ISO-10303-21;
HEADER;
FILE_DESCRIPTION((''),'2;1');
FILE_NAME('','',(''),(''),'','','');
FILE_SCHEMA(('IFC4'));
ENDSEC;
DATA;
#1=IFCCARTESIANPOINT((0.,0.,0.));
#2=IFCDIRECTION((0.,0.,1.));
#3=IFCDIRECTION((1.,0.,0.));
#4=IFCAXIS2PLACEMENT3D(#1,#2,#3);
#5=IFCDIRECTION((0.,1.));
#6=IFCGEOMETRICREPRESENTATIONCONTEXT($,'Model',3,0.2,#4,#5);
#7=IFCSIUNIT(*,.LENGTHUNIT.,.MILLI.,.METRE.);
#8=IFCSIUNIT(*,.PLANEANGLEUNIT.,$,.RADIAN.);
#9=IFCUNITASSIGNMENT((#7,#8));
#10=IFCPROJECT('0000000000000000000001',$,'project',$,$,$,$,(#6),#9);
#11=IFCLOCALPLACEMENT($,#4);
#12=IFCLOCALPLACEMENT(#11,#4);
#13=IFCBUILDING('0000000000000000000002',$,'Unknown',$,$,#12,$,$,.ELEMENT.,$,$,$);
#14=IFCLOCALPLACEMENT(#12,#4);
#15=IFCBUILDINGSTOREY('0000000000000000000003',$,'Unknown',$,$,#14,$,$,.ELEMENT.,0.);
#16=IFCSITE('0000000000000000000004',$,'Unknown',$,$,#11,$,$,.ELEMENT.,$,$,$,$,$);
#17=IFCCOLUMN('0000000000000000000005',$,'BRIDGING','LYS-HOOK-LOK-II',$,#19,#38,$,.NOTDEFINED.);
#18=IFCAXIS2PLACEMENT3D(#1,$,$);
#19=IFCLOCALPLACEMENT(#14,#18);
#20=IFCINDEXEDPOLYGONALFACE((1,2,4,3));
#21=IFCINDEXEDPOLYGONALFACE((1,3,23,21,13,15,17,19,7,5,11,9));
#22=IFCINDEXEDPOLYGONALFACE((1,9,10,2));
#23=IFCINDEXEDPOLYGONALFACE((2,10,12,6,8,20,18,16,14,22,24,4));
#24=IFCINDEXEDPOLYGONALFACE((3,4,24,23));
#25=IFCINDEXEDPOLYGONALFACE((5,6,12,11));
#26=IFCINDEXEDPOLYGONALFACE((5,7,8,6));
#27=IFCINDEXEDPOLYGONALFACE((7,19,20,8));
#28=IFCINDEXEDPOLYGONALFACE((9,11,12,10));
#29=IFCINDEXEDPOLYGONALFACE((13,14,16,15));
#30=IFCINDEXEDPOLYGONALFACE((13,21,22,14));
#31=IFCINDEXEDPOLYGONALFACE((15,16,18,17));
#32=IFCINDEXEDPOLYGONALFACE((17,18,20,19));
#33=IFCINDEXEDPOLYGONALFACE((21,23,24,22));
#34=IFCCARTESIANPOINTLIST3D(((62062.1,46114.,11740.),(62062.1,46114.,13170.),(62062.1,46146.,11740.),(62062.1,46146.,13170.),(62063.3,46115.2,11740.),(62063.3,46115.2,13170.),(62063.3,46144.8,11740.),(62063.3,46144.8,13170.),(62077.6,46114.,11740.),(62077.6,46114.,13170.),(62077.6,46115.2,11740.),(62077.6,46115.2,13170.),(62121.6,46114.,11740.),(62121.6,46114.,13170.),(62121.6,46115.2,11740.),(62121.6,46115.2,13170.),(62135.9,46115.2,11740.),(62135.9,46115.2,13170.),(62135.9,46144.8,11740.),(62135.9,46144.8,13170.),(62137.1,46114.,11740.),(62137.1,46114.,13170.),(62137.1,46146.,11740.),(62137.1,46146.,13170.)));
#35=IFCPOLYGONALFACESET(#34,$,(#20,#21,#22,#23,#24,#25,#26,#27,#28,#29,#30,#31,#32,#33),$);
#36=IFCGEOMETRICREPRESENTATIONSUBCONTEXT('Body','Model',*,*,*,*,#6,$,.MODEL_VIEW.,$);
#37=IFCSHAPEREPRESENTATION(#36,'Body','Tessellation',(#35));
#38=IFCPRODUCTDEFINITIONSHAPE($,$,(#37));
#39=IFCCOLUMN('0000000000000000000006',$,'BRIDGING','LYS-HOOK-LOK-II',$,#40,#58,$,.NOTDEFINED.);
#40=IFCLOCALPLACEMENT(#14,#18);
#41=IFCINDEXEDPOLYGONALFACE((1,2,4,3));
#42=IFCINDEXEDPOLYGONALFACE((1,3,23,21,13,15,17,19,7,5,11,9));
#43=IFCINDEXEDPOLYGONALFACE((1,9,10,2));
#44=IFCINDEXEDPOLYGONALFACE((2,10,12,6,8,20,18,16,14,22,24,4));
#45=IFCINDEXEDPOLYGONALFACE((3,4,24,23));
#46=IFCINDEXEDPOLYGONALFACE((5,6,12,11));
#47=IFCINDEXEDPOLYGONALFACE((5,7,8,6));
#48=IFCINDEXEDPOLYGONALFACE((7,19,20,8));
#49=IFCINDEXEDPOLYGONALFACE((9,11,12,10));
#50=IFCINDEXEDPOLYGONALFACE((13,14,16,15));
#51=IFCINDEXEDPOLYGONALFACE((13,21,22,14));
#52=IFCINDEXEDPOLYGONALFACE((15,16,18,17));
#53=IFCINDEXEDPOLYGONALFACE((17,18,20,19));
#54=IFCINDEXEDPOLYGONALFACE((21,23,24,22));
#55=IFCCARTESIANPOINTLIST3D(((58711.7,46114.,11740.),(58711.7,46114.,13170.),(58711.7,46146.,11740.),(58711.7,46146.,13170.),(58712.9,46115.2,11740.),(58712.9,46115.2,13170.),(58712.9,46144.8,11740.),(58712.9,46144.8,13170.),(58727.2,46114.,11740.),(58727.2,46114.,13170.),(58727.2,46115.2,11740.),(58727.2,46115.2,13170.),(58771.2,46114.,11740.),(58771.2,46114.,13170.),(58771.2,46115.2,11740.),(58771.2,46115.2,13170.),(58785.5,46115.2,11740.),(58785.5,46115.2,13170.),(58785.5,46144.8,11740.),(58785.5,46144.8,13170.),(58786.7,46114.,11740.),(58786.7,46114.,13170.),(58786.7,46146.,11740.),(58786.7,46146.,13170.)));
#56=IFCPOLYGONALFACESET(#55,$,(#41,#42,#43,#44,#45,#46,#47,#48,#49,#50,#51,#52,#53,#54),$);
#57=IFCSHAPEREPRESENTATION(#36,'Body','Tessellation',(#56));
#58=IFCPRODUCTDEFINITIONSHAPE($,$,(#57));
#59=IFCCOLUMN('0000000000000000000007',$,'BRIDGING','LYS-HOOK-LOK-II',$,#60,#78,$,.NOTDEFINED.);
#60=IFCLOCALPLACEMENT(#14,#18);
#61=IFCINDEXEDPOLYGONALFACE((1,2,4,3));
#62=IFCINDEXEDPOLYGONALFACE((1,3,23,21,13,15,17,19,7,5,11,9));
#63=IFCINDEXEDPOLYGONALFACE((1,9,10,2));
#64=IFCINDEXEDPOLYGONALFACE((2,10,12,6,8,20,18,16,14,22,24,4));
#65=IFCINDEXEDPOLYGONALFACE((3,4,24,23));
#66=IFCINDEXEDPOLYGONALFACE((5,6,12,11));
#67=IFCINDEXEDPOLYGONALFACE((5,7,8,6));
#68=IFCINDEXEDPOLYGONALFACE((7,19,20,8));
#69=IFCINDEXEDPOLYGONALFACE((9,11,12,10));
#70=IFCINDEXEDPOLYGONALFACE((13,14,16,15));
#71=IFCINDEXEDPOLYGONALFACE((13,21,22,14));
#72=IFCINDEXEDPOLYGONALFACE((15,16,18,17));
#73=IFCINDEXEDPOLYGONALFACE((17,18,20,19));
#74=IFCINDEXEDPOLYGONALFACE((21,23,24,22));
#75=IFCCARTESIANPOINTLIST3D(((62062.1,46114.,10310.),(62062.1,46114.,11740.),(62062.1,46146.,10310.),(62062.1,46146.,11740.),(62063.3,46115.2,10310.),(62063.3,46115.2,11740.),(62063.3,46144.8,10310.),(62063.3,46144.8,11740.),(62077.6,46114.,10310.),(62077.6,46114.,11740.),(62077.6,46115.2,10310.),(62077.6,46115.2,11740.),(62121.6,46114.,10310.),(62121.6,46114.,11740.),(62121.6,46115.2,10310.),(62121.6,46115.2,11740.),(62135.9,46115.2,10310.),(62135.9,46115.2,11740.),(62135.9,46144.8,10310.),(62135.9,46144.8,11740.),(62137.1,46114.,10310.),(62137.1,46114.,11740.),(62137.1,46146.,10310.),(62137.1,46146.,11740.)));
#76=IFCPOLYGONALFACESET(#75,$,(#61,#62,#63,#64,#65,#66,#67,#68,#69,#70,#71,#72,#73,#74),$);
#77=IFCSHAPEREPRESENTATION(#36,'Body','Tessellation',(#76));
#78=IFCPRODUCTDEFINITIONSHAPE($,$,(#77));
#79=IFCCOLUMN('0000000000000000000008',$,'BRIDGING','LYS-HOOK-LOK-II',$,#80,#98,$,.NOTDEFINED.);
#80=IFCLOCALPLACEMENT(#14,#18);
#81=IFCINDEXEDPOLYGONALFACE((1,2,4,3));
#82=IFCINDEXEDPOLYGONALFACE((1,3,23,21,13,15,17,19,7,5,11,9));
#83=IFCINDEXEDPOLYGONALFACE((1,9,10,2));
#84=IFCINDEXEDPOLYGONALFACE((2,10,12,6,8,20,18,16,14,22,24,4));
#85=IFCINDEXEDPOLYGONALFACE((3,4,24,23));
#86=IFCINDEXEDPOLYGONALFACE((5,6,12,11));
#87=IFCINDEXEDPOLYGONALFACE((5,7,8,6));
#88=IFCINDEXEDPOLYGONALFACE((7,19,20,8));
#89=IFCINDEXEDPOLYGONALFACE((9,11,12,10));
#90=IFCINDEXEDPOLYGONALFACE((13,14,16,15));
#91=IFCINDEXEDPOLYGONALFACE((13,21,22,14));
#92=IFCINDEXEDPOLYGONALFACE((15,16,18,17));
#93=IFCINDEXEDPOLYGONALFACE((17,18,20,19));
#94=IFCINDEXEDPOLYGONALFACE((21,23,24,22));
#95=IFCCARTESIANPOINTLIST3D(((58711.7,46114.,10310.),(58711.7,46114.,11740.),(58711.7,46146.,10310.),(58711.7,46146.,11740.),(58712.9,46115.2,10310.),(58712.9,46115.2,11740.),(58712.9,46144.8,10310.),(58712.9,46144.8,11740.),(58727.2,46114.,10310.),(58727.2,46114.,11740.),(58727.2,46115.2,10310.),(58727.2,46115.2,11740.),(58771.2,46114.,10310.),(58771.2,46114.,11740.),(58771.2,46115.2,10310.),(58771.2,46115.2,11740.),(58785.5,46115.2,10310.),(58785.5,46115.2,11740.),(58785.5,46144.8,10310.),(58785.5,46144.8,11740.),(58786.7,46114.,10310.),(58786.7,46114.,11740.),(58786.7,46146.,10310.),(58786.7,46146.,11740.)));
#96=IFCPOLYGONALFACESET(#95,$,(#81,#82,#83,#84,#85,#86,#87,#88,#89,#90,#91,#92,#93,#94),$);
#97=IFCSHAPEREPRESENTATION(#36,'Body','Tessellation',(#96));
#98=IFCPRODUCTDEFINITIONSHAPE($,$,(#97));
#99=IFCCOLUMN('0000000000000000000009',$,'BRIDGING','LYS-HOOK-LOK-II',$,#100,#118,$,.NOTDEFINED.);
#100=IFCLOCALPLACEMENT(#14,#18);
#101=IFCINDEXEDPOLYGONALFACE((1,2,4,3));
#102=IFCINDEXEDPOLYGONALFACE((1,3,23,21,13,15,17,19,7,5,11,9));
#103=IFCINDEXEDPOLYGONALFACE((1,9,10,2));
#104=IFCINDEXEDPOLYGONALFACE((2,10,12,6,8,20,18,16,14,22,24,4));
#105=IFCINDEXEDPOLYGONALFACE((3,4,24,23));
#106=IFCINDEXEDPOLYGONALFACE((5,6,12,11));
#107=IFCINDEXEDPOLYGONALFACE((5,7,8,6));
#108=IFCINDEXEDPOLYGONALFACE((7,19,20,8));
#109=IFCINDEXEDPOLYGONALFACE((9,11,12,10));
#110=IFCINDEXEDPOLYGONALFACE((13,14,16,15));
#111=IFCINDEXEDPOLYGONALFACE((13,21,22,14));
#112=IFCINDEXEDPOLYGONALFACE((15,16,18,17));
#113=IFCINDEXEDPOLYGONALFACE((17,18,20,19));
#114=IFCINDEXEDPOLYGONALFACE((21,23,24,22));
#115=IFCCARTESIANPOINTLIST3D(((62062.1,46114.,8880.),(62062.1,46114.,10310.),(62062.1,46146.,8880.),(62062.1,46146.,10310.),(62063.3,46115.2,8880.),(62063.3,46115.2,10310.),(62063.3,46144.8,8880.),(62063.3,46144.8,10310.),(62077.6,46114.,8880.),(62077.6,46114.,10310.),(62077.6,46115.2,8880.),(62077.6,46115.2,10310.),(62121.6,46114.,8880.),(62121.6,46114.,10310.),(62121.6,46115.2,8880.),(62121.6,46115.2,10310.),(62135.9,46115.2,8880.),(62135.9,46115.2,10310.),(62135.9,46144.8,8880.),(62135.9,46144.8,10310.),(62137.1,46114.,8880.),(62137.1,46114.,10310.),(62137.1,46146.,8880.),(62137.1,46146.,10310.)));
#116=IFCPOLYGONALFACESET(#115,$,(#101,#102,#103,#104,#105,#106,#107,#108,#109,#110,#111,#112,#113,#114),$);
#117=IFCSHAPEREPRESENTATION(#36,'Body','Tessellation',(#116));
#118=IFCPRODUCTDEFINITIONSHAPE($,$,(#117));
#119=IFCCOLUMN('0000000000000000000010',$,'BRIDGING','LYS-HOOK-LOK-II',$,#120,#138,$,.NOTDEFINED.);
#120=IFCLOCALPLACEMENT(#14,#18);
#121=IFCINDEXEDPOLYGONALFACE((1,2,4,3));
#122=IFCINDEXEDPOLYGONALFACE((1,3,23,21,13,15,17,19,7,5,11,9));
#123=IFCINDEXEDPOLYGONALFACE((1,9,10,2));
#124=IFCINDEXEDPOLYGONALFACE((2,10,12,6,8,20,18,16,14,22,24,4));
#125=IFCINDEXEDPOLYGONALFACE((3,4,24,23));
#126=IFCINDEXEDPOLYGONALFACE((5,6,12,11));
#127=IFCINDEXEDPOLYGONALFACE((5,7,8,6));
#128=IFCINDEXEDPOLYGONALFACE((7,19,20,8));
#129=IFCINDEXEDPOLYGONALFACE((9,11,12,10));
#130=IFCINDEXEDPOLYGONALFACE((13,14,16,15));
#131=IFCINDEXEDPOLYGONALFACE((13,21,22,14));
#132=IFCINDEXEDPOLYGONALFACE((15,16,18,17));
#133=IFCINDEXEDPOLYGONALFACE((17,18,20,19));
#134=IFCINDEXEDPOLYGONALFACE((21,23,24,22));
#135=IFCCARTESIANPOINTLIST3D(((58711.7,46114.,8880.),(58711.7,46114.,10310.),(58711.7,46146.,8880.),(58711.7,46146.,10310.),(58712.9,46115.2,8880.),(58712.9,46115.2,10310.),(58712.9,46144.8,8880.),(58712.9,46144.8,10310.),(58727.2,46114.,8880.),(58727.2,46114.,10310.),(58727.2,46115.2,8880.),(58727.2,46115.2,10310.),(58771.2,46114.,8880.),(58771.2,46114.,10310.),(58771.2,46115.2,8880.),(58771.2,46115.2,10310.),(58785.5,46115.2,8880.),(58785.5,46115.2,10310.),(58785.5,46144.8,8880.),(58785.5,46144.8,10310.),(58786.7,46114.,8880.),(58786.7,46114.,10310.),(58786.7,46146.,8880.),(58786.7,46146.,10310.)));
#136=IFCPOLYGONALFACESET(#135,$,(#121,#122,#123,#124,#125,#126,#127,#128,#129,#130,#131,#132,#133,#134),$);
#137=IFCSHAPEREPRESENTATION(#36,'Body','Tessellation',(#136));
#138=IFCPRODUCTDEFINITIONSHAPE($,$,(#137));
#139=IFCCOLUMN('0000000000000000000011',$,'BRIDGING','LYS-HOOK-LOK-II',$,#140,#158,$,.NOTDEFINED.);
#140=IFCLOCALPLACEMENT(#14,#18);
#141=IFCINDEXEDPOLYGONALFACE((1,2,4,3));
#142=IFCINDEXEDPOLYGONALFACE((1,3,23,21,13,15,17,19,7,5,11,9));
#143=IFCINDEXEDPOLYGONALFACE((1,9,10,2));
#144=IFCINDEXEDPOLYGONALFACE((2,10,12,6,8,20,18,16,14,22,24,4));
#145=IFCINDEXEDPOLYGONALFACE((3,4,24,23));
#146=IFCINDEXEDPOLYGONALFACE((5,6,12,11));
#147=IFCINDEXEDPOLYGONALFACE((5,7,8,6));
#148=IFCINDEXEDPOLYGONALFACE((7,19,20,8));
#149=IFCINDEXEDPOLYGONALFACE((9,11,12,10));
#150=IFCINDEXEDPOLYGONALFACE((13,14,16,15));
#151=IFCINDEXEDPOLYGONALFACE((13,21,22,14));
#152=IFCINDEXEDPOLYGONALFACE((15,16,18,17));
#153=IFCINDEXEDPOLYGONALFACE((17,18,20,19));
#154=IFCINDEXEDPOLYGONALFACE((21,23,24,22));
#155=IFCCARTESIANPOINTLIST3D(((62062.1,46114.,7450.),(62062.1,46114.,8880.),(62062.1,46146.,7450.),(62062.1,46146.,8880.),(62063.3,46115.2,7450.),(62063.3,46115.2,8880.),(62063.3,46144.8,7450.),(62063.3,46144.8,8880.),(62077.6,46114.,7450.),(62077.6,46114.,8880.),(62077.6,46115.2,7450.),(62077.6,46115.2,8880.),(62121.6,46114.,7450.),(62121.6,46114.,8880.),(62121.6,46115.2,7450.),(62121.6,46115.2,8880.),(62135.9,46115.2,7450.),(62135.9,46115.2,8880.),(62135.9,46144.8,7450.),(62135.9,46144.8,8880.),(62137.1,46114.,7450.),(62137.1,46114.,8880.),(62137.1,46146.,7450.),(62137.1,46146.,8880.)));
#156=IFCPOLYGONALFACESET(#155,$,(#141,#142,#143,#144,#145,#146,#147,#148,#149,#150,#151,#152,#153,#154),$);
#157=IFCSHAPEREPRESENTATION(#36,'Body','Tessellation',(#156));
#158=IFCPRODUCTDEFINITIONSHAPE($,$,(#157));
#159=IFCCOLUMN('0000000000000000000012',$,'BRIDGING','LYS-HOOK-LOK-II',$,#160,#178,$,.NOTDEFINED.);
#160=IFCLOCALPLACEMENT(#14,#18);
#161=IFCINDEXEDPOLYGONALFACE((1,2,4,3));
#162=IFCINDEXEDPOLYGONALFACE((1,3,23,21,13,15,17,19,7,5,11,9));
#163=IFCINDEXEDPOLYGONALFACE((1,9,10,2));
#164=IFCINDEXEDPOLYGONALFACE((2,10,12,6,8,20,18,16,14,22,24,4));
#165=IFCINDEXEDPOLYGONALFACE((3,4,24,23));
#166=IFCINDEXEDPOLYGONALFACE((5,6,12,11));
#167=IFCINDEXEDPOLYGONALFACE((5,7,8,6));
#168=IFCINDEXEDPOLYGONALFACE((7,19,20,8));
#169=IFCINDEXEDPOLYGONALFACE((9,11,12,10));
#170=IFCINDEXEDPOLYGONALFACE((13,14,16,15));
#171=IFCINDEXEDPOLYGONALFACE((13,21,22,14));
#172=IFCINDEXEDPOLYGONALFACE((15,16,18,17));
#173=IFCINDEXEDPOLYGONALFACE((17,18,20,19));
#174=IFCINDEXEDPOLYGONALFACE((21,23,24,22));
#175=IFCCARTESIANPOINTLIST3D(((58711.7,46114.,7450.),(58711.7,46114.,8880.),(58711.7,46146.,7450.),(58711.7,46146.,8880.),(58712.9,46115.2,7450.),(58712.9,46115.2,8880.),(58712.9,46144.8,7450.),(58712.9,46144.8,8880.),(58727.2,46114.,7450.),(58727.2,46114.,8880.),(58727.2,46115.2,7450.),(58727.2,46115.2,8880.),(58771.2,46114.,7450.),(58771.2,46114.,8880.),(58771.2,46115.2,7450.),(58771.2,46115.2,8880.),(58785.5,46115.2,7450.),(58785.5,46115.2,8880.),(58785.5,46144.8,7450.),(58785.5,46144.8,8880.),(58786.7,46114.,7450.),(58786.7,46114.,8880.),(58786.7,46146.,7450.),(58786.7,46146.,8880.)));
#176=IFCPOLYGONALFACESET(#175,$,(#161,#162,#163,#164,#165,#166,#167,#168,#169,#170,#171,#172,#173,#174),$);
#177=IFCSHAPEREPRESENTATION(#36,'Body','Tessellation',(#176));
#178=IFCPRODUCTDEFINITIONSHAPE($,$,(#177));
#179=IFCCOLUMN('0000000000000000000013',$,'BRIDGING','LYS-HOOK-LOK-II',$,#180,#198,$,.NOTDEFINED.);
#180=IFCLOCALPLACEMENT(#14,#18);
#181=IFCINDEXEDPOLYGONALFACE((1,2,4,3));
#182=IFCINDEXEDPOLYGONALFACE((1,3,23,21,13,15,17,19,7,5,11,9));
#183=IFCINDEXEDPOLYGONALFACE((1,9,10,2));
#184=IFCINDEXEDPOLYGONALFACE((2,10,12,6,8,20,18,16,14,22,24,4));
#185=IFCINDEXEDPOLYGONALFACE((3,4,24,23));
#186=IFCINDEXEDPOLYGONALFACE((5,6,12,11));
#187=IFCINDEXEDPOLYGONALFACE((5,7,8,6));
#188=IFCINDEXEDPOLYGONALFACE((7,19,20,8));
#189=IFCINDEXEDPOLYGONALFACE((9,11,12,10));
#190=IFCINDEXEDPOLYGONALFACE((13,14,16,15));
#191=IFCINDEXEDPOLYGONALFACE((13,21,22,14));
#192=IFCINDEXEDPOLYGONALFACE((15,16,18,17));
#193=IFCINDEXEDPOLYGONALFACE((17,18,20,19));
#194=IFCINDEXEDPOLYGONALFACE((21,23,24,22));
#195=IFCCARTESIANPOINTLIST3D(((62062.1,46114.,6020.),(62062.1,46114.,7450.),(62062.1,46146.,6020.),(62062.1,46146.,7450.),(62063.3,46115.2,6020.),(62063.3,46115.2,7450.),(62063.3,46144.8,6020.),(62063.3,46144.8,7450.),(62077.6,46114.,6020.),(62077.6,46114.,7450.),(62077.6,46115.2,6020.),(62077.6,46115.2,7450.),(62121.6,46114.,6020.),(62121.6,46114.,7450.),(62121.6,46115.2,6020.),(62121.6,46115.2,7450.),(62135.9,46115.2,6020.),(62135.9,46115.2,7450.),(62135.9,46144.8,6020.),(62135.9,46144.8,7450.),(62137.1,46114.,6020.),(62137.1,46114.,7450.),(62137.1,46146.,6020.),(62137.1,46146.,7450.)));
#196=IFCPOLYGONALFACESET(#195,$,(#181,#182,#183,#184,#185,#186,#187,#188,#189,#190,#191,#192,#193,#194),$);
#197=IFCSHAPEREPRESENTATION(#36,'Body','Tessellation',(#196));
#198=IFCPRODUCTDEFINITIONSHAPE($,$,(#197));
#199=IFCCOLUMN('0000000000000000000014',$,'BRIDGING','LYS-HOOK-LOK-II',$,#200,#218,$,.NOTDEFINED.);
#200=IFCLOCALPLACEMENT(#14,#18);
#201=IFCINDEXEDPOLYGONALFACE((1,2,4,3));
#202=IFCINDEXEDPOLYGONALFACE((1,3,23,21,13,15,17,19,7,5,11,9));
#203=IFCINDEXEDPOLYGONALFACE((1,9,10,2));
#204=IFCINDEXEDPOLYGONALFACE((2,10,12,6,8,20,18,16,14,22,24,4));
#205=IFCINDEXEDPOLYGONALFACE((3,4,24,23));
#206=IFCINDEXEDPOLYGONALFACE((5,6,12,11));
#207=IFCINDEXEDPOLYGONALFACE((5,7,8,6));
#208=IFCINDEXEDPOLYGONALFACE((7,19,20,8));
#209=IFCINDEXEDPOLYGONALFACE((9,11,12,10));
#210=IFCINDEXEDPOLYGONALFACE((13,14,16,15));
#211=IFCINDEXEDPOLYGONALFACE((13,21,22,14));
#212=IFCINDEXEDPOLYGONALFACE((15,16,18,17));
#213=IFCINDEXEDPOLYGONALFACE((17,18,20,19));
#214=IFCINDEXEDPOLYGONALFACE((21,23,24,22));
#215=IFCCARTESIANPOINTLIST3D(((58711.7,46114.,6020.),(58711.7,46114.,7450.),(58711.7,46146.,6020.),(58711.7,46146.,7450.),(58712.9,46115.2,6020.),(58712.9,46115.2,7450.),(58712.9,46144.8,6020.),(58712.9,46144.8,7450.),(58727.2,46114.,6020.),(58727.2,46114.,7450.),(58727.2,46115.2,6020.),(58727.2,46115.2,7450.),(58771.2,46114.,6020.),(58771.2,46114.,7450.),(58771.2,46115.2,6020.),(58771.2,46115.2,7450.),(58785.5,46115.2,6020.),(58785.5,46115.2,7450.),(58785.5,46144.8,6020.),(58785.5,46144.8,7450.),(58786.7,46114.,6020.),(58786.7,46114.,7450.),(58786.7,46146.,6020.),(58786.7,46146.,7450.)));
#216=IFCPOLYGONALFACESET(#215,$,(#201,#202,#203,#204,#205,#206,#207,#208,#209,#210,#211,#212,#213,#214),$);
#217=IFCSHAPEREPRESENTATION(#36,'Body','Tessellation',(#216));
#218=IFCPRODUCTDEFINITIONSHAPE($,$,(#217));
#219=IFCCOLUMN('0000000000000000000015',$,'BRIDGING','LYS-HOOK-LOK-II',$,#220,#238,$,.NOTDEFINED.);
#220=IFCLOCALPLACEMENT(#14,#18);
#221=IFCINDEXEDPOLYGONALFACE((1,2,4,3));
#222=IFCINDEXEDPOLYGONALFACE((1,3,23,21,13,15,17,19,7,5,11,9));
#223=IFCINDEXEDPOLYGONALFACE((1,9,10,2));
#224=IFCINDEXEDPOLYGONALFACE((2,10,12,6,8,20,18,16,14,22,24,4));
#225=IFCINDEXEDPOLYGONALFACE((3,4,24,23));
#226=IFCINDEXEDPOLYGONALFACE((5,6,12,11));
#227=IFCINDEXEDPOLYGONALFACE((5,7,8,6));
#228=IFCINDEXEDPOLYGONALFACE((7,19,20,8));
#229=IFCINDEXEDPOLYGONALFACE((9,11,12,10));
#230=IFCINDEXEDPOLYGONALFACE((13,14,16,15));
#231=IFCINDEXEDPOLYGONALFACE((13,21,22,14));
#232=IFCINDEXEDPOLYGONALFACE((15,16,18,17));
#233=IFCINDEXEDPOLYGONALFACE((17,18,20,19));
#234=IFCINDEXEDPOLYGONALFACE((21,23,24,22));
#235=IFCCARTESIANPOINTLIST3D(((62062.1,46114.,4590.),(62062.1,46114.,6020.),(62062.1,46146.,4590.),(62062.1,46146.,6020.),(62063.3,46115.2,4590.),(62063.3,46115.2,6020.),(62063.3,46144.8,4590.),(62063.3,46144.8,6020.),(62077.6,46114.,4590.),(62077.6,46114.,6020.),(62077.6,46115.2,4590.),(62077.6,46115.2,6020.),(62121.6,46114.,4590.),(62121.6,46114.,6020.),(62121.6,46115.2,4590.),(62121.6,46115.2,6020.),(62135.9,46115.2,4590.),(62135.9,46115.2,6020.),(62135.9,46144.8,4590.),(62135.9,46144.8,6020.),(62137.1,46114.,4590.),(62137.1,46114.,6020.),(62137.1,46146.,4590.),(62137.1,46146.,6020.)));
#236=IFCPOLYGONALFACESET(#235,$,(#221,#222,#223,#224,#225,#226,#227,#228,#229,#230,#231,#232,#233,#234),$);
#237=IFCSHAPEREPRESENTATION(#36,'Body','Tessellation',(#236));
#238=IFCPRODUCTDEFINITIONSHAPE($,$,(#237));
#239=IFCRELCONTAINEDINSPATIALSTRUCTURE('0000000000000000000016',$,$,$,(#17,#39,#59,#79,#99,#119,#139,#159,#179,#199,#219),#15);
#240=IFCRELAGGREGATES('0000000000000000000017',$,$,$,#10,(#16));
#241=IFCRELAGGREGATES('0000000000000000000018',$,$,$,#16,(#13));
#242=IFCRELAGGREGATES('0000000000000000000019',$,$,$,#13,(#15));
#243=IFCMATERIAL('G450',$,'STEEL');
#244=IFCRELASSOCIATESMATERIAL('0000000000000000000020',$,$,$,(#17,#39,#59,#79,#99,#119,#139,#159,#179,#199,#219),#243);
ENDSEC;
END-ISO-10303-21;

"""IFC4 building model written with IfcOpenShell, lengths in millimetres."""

from ifc_helpers import new_model, si_unit, direction, frame, origin_with_axes, place, context, subcontext, project, spatial, line, indexed_curve, outline, extrude, material, element, save


model = new_model("IFC4")

# Units and contexts
model_context = context("Model", 3, precision=0.2, world=origin_with_axes(), true_north=direction((0.0, 1.0)))
body_context = subcontext(model_context, "Body", "Model", "MODEL_VIEW")
ifc_project = project(units=[si_unit("LENGTHUNIT", "METRE", prefix="MILLI"), si_unit("PLANEANGLEUNIT", "RADIAN")], contexts=[model_context])

# Site, building, storey
site_placement = place(None, origin_with_axes())
site = spatial("IfcSite", under=ifc_project, at=site_placement, Name="Unknown", CompositionType="ELEMENT")
building_placement = place(site_placement, origin_with_axes())
building = spatial("IfcBuilding", under=site, at=building_placement, Name="Unknown", CompositionType="ELEMENT")
storey_placement = place(building_placement, origin_with_axes())
storey = spatial("IfcBuildingStorey", under=building, at=storey_placement, Name="Unknown", CompositionType="ELEMENT", Elevation=0.0)

# Columns
ifc_material_1 = material(Name="G450", Category="STEEL")
for number, where, z_axis, x_axis, name in (
    (1, (62099.6, 46130.0, 11740.0), (0.0, -1.0, 0.0), (0.0, 0.0, 1.0), "BRIDGING"),
    (2, (58749.2, 46130.0, 11740.0), (0.0, -1.0, 0.0), (0.0, 0.0, 1.0), "BRIDGING"),
    (3, (62099.6, 46130.0, 10310.0), (0.0, -1.0, 0.0), (0.0, 0.0, 1.0), "BRIDGING"),
    (4, (58749.2, 46130.0, 10310.0), (0.0, -1.0, 0.0), (0.0, 0.0, 1.0), "BRIDGING"),
    (5, (62099.6, 46130.0, 8880.0), (0.0, -1.0, 0.0), (0.0, 0.0, 1.0), "BRIDGING"),
    (6, (58749.2, 46130.0, 8880.0), (0.0, -1.0, 0.0), (0.0, 0.0, 1.0), "BRIDGING"),
    (7, (62099.6, 46130.0, 7450.0), (0.0, -1.0, 0.0), (0.0, 0.0, 1.0), "BRIDGING"),
    (8, (58749.2, 46130.0, 7450.0), (0.0, -1.0, 0.0), (0.0, 0.0, 1.0), "BRIDGING"),
    (9, (62099.6, 46130.0, 6020.0), (0.0, -1.0, 0.0), (0.0, 0.0, 1.0), "BRIDGING"),
    (10, (58749.2, 46130.0, 6020.0), (0.0, -1.0, 0.0), (0.0, 0.0, 1.0), "BRIDGING"),
    (11, (62099.6, 46130.0, 4590.0), (0.0, -1.0, 0.0), (0.0, 0.0, 1.0), "BRIDGING"),
):
    element("IfcColumn", number, at=place(storey_placement, frame(where, z_axis=z_axis, x_axis=x_axis)), inside=storey, material=ifc_material_1, Name=name, Description="LYS-HOOK-LOK-II", PredefinedType="NOTDEFINED", context=body_context, shape_type="SolidModel", body=[
        extrude(outline(indexed_curve([(16.0, -37.5), (16.0, -22.0), (14.8, -22.0), (14.8, -36.3), (-14.8, -36.3), (-14.8, 36.3), (14.8, 36.3), (14.8, 22.0), (16.0, 22.0), (16.0, 37.5), (-16.0, 37.5), (-16.0, -37.5)], segments=[line(1, 2, 3, 4, 5, 6, 7, 8, 9, 10, 11, 12, 1)])), frame((0.0, 0.0, 0.0), z_axis=(-1.0, 0.0, 0.0), x_axis=(0.0, 0.0, 1.0)), (0.0, 0.0, -1.0), 1430.0),
    ])

save(model, "model.ifc")
